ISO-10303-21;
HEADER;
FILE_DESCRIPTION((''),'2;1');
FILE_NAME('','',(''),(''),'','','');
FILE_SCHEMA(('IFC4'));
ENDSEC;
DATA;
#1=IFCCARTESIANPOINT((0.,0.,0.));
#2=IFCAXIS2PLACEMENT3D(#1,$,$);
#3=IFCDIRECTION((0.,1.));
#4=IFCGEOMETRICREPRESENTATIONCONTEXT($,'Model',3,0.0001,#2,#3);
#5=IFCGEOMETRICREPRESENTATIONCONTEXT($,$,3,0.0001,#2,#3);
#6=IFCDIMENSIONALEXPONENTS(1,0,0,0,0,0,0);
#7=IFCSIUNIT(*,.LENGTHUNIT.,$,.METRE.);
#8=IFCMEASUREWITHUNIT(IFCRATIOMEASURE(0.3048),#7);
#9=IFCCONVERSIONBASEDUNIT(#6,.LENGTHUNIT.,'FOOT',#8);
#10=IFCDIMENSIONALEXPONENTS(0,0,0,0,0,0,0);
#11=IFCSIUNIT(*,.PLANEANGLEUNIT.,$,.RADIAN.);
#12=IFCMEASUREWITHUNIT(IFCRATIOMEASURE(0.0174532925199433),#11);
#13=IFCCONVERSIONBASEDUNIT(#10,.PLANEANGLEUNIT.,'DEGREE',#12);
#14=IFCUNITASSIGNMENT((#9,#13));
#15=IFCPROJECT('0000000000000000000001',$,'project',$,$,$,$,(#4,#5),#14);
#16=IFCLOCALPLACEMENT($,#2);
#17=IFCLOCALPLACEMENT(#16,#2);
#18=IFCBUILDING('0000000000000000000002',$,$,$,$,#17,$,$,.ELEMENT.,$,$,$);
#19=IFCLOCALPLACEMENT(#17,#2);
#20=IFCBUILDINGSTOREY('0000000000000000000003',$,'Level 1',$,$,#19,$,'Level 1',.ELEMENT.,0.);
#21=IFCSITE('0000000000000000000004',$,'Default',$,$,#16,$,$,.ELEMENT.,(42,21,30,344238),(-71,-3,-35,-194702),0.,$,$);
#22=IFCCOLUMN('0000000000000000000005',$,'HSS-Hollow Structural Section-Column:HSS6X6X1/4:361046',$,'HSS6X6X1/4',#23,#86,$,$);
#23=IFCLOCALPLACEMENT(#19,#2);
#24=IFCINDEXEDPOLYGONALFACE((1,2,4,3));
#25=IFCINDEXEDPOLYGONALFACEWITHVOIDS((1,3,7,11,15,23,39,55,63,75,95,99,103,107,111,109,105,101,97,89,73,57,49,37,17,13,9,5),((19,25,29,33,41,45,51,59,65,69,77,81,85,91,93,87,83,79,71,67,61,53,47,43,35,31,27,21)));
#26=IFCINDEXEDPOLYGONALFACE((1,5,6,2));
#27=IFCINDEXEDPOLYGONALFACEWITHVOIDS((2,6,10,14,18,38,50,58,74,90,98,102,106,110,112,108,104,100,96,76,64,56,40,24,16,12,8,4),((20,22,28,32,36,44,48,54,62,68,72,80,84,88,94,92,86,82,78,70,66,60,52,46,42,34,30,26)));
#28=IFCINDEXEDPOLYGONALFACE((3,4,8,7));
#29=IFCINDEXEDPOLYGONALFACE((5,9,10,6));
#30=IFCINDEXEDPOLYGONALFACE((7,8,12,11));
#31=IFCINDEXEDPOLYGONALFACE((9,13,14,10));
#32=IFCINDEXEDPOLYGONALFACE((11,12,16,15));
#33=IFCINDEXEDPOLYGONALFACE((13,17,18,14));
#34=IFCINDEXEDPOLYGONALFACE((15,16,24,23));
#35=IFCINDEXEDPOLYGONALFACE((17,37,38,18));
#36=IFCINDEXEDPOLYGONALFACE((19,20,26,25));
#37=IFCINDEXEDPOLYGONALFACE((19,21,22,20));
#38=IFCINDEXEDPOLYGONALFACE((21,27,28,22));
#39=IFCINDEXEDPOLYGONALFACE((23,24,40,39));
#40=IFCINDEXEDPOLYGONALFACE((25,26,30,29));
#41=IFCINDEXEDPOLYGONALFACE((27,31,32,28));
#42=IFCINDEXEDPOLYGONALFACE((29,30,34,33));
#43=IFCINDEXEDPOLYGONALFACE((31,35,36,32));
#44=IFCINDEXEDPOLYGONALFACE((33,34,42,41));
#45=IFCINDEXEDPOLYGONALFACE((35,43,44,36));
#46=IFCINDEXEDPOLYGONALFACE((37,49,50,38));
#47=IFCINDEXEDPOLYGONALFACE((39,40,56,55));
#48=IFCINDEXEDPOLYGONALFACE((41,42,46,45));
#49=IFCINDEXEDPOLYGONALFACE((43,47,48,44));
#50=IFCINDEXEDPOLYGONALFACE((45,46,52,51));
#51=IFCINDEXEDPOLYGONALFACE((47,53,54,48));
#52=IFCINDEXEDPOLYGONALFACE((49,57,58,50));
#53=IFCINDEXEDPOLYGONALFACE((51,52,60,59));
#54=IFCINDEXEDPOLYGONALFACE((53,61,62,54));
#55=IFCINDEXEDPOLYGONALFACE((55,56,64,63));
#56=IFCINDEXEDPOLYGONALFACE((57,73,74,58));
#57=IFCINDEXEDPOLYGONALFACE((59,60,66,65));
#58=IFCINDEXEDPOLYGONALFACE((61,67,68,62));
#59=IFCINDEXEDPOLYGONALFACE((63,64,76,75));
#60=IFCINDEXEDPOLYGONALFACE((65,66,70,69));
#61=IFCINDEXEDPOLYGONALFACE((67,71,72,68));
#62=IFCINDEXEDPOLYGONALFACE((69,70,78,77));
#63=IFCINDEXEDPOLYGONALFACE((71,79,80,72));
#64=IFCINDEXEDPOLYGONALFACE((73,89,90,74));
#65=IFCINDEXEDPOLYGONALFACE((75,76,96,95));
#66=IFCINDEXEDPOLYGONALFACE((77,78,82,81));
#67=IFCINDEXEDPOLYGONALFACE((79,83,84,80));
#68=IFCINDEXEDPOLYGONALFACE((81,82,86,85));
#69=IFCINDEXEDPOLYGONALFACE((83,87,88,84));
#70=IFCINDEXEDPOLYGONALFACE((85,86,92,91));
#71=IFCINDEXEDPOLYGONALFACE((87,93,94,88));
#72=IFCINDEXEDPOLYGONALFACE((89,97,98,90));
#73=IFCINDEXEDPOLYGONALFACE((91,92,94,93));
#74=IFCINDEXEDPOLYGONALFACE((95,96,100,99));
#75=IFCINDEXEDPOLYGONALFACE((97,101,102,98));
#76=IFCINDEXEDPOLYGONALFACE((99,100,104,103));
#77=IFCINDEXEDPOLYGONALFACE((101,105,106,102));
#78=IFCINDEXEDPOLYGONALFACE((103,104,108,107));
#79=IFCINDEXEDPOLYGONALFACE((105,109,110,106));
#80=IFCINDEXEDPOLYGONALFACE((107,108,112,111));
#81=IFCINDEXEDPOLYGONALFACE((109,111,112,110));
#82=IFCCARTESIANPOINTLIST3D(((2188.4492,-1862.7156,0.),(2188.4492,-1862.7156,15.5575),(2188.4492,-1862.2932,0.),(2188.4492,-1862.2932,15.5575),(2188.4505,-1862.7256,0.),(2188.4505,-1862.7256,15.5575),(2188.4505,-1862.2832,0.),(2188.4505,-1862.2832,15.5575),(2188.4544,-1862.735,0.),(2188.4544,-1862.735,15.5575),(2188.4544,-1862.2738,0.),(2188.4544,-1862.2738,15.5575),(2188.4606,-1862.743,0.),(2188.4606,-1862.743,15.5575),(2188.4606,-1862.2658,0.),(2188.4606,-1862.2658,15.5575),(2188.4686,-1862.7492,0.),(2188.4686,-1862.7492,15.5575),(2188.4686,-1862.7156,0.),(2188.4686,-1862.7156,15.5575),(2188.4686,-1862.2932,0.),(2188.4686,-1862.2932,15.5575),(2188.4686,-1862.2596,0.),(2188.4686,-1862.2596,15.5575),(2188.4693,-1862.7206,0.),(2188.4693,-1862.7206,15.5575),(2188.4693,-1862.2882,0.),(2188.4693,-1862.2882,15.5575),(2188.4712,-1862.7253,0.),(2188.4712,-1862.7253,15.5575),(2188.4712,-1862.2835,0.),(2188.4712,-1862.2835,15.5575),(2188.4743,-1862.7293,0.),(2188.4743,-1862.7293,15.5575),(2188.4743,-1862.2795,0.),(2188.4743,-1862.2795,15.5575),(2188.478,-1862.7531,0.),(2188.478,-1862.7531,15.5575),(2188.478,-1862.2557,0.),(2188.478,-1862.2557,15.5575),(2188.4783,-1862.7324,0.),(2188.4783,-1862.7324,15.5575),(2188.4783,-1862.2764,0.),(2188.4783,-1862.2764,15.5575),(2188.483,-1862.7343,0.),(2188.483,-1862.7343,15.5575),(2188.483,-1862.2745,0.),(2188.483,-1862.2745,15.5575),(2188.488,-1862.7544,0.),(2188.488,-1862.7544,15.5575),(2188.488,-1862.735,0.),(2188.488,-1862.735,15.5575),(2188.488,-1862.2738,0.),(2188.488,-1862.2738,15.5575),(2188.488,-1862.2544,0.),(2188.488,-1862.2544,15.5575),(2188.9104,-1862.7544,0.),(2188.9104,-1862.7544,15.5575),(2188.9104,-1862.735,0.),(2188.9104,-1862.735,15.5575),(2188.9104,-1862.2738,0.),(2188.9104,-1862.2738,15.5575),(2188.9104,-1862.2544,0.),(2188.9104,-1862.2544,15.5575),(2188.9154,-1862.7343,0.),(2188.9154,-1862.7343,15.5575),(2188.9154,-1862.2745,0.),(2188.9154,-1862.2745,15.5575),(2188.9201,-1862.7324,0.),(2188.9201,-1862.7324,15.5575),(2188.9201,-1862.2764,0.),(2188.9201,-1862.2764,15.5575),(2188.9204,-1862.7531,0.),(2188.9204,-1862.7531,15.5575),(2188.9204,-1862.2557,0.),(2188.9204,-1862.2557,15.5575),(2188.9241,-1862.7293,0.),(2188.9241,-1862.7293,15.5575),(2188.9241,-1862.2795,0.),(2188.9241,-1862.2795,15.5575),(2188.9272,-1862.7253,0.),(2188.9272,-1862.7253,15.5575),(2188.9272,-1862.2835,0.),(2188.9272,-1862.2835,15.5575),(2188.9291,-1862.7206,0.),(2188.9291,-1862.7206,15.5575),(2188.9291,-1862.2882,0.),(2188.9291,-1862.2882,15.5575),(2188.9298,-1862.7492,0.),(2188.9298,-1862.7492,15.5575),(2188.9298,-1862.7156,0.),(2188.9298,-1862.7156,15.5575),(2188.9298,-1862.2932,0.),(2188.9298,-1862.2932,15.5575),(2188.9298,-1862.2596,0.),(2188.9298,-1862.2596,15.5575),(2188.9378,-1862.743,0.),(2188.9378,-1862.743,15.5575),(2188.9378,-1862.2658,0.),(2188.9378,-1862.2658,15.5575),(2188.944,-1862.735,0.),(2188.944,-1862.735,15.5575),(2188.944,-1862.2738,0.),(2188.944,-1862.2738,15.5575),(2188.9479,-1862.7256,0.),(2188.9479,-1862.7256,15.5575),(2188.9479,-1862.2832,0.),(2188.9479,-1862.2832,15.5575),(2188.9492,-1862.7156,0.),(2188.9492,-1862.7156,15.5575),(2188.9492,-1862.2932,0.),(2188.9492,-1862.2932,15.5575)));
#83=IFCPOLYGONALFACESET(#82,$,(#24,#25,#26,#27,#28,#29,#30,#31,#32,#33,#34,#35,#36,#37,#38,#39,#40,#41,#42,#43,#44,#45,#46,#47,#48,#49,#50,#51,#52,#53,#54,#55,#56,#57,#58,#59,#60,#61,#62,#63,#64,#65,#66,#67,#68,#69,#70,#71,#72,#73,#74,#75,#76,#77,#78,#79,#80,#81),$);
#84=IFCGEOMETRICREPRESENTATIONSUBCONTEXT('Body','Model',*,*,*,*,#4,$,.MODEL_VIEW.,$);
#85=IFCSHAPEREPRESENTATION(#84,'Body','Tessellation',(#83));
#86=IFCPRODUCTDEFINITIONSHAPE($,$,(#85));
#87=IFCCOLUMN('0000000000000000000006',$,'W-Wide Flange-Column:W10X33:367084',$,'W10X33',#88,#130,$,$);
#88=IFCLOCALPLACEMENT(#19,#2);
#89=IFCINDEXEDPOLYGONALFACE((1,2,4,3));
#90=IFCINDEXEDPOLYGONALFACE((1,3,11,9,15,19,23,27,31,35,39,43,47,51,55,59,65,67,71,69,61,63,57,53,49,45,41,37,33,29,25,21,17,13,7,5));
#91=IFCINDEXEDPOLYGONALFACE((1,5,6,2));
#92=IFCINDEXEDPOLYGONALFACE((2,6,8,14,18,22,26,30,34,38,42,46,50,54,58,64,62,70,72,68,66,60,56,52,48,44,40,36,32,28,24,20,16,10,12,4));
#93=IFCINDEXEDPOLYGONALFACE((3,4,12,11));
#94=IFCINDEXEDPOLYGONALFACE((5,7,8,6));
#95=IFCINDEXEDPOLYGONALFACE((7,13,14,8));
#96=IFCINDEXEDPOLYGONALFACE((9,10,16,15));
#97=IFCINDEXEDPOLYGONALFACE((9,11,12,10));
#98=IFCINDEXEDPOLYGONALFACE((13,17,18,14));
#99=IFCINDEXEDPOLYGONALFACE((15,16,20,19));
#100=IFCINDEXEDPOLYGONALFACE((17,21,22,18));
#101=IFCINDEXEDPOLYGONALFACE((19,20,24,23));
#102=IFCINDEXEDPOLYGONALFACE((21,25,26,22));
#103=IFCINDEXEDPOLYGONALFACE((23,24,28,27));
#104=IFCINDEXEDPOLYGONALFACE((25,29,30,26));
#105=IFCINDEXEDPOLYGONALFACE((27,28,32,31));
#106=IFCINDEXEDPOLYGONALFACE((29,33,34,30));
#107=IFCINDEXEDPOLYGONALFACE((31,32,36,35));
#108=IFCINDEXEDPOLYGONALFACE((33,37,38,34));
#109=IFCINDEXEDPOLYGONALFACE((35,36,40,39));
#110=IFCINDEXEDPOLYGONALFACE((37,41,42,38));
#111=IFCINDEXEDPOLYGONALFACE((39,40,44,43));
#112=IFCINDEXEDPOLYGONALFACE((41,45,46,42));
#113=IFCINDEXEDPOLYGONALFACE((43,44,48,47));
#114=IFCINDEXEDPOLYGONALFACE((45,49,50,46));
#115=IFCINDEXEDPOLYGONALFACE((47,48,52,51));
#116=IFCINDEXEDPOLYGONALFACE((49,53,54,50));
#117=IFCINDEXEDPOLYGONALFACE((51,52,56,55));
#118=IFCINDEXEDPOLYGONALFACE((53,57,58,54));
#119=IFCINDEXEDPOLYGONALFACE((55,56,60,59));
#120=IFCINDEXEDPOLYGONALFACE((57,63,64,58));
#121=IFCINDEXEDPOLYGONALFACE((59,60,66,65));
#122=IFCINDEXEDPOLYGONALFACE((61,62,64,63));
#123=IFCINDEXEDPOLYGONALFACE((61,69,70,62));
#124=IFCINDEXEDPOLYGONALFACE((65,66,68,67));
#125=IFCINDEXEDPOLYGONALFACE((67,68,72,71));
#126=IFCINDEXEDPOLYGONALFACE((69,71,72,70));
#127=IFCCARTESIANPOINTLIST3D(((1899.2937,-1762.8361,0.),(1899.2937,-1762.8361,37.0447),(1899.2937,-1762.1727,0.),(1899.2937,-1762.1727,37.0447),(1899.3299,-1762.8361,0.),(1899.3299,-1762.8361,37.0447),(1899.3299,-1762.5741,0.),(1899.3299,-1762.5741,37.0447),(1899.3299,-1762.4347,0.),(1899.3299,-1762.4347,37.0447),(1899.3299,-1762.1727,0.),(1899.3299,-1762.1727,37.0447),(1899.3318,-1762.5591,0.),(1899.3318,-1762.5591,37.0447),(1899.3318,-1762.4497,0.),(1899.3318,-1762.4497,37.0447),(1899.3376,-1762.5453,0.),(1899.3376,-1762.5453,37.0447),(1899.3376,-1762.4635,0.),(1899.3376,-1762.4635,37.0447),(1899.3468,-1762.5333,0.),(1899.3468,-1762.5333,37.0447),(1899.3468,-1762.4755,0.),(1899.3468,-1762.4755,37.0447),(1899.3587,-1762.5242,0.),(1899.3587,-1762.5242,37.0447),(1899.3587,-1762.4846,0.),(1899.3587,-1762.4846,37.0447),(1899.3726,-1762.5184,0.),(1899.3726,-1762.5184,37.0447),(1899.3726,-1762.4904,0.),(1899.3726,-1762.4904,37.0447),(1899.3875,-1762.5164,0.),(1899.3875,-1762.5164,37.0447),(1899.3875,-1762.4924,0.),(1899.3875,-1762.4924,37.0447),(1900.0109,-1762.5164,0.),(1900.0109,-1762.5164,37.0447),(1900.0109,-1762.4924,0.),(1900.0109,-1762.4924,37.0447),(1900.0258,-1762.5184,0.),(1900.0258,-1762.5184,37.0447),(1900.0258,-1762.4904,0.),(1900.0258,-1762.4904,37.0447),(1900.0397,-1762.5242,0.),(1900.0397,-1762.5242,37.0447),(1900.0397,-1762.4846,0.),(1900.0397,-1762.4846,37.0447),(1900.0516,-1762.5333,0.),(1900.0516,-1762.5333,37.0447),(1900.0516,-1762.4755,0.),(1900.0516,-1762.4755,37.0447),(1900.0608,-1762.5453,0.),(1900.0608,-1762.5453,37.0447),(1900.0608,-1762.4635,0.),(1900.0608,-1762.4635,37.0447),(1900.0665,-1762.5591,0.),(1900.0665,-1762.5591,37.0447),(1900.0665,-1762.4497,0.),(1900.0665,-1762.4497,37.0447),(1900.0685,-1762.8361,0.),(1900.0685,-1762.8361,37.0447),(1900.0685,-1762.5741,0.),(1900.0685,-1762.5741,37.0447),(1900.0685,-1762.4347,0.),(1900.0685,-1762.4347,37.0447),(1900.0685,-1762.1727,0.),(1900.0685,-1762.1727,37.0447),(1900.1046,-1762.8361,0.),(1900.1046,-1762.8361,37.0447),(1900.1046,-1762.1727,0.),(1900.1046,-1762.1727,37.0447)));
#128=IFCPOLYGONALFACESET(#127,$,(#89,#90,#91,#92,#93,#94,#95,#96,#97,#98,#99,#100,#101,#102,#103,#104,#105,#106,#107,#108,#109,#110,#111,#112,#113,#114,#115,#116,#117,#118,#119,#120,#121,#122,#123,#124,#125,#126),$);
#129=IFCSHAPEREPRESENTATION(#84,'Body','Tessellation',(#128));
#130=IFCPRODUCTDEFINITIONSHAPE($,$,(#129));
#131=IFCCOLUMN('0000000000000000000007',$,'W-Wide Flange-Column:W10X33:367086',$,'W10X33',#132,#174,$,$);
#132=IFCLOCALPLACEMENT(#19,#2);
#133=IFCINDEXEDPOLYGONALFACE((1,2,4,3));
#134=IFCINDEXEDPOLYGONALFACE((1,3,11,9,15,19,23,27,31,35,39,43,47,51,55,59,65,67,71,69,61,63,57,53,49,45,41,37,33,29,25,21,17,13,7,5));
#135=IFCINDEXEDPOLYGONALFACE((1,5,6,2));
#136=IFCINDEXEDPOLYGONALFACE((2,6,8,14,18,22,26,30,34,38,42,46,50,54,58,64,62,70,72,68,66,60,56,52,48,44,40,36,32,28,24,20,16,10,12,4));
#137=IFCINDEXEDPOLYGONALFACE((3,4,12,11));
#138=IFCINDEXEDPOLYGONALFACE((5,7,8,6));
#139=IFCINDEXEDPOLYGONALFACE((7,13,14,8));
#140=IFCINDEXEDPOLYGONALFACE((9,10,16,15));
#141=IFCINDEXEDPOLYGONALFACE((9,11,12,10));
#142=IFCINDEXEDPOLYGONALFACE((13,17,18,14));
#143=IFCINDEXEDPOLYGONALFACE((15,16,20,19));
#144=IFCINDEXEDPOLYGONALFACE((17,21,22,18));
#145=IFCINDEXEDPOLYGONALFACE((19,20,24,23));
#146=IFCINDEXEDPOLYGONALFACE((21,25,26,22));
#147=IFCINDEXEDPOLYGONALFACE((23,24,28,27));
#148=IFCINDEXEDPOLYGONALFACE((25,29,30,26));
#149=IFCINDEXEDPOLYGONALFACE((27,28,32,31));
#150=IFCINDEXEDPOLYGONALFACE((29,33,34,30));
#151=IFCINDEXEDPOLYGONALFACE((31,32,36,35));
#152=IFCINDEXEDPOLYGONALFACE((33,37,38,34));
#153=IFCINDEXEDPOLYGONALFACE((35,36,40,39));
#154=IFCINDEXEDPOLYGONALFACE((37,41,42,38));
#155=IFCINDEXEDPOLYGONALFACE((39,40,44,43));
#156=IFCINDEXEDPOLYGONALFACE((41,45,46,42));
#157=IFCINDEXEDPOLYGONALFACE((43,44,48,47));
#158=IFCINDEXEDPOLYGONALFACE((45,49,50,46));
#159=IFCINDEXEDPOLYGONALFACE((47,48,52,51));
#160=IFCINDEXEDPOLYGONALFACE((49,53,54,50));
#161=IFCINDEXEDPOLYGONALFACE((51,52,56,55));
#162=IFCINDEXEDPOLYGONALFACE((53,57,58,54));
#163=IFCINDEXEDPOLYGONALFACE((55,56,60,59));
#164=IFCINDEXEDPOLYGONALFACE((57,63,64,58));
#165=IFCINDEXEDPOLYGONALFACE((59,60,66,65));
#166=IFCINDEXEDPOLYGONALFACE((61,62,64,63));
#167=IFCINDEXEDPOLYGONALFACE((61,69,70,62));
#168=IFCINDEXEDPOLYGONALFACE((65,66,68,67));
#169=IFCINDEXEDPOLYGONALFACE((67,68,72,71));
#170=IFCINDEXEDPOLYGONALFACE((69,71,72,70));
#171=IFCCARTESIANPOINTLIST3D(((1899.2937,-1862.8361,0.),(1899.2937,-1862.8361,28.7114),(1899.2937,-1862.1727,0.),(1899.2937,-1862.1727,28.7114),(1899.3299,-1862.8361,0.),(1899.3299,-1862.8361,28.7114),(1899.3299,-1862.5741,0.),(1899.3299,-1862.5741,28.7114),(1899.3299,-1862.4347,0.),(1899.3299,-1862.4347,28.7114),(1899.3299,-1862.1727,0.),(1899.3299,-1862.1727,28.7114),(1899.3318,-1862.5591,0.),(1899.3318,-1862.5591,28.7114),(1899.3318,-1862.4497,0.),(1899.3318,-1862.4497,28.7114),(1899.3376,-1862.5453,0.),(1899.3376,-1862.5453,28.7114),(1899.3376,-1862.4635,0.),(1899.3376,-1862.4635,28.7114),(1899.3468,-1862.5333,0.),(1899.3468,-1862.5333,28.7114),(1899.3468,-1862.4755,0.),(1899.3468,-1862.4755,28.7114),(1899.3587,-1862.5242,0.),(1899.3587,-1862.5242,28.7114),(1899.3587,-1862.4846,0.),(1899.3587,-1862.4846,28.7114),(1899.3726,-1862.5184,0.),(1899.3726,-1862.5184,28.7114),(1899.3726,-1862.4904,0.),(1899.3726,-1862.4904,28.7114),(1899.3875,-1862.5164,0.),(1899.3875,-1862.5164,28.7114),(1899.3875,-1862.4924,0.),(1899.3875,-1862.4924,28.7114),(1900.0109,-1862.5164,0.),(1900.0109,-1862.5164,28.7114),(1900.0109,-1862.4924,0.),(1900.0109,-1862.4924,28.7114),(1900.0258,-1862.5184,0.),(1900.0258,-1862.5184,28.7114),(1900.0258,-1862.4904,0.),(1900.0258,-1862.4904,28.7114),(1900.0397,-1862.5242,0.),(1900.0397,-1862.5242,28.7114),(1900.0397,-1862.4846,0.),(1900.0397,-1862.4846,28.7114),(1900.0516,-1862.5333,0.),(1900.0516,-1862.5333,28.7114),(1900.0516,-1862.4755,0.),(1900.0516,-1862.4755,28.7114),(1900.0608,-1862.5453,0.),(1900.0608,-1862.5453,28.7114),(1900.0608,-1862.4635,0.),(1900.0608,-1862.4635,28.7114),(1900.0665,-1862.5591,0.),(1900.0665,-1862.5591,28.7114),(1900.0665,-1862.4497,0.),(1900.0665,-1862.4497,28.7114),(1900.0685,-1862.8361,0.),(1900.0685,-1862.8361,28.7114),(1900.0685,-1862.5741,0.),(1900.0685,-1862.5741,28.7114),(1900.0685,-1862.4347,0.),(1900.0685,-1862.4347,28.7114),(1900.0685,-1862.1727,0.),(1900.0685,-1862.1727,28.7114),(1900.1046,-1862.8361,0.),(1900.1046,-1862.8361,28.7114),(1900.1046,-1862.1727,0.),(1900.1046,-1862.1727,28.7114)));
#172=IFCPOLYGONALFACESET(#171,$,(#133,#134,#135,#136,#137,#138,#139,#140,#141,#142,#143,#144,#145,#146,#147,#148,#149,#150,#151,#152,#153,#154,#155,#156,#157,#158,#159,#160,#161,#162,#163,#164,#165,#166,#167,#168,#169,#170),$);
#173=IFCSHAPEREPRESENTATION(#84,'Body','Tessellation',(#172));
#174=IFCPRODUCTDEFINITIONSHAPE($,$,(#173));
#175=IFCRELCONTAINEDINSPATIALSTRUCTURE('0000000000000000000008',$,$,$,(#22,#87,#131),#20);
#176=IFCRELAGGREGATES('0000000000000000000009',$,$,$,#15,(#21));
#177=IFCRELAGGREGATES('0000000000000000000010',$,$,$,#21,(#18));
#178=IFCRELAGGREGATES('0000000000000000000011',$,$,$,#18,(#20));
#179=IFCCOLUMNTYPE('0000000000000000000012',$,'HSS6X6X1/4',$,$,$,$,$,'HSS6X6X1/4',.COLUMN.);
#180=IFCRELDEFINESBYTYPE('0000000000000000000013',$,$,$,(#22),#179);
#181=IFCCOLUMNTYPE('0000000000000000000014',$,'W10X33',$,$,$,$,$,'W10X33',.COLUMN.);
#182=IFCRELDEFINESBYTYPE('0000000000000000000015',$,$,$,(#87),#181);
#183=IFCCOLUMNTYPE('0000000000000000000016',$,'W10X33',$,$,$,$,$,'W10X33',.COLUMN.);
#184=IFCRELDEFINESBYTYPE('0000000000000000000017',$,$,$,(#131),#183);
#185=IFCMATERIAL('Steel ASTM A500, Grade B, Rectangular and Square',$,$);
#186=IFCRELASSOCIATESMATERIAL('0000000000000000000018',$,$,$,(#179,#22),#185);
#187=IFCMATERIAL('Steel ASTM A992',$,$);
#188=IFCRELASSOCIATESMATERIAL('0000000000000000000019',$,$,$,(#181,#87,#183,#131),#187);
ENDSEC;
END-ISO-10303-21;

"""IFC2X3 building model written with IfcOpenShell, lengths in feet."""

from ifc_helpers import new_model, entity, si_unit, converted_unit, direction, frame, frame_2d, origin, place, context, subcontext, project, spatial, polyline, circle_curve, parameter, trimmed, segment, composite_curve, i_section, outline, extrude, source, transform, mapped, material, type_object, type_shapes, element, save


model = new_model("IFC2X3")

# Units and contexts
model_context = context("Model", 3, precision=0.0001, world=origin(), true_north=direction((0.0, 1.0)))
context_of_model = context(None, 3, precision=0.0001, world=origin(), true_north=direction((0.0, 1.0)))
body_context = subcontext(model_context, "Body", "Model", "MODEL_VIEW")
ifc_project = project(units=[converted_unit("LENGTHUNIT", "FOOT", entity("IfcRatioMeasure", 0.3048), si_unit("LENGTHUNIT", "METRE"), dimensions=[1, 0, 0, 0, 0, 0, 0]), converted_unit("PLANEANGLEUNIT", "DEGREE", entity("IfcRatioMeasure", 0.0174532925199433), si_unit("PLANEANGLEUNIT", "RADIAN"), dimensions=[0, 0, 0, 0, 0, 0, 0])], contexts=[model_context, context_of_model])

# Site, building, storey
site_placement = place(None, origin())
site = spatial("IfcSite", under=ifc_project, at=site_placement, Name="Default", CompositionType="ELEMENT", RefLatitude=(42, 21, 30, 344238), RefLongitude=(-71, -3, -35, -194702), RefElevation=0.0)
building_placement = place(site_placement, origin())
building = spatial("IfcBuilding", under=site, at=building_placement, CompositionType="ELEMENT")
storey_placement = place(building_placement, origin())
storey = spatial("IfcBuildingStorey", under=building, at=storey_placement, Name="Level 1", LongName="Level 1", CompositionType="ELEMENT", Elevation=0.0)

# Columns
ifc_material_1 = material(Name="Steel ASTM A500, Grade B, Rectangular and Square")
column_type_1 = type_object("IfcColumnType", Name="HSS6X6X1/4", ElementType="HSS6X6X1/4", PredefinedType="COLUMN", material=ifc_material_1)
shared_shape_1 = source(origin(), body_context, "Body", "SweptSolid", [
    extrude(outline(composite_curve([segment(polyline([(-0.2112, -0.25), (0.2112, -0.25)]), True, "CONTINUOUS"), segment(trimmed(circle_curve(frame_2d((0.2112, -0.2112), x_axis=(-1.0, 0.0)), 0.0388), [parameter(90.0)], [parameter(180.0)], True, "PARAMETER"), True, "CONTINUOUS"), segment(polyline([(0.25, -0.2112), (0.25, 0.2112)]), True, "CONTINUOUS"), segment(trimmed(circle_curve(frame_2d((0.2112, 0.2112), x_axis=(-1.0, 0.0)), 0.0388), [parameter(180.0)], [parameter(270.0)], True, "PARAMETER"), True, "CONTINUOUS"), segment(polyline([(0.2112, 0.25), (-0.2112, 0.25)]), True, "CONTINUOUS"), segment(trimmed(circle_curve(frame_2d((-0.2112, 0.2112), x_axis=(-1.0, 0.0)), 0.0388), [parameter(270.0)], [parameter(360.0)], True, "PARAMETER"), True, "CONTINUOUS"), segment(polyline([(-0.25, 0.2112), (-0.25, -0.2112)]), True, "CONTINUOUS"), segment(trimmed(circle_curve(frame_2d((-0.2112, -0.2112), x_axis=(-1.0, 0.0)), 0.0388), [parameter(360.0)], [parameter(90.0)], True, "PARAMETER"), True, "CONTINUOUS")], self_intersect=False), holes=[composite_curve([segment(trimmed(circle_curve(frame_2d((-0.2112, -0.2112), x_axis=(-1.0, 0.0)), 0.0194), [parameter(0.0)], [parameter(90.0)], True, "PARAMETER"), False, "CONTINUOUS"), segment(polyline([(-0.2306, -0.2112), (-0.2306, 0.2112)]), True, "CONTINUOUS"), segment(trimmed(circle_curve(frame_2d((-0.2112, 0.2112), x_axis=(-1.0, 0.0)), 0.0194), [parameter(270.0)], [parameter(360.0)], True, "PARAMETER"), False, "CONTINUOUS"), segment(polyline([(-0.2112, 0.2306), (0.2112, 0.2306)]), True, "CONTINUOUS"), segment(trimmed(circle_curve(frame_2d((0.2112, 0.2112), x_axis=(-1.0, 0.0)), 0.0194), [parameter(180.0)], [parameter(270.0)], True, "PARAMETER"), False, "CONTINUOUS"), segment(polyline([(0.2306, 0.2112), (0.2306, -0.2112)]), True, "CONTINUOUS"), segment(trimmed(circle_curve(frame_2d((0.2112, -0.2112), x_axis=(-1.0, 0.0)), 0.0194), [parameter(90.0)], [parameter(180.0)], True, "PARAMETER"), False, "CONTINUOUS"), segment(polyline([(0.2112, -0.2306), (-0.2112, -0.2306)]), True, "CONTINUOUS")], self_intersect=False)]), frame((2188.6992, -1862.5044, 0.0), z_axis=(0.0, 0.0, 1.0), x_axis=(-1.0, 0.0, 0.0)), (0.0, 0.0, 1.0), 15.5575),
])
type_shapes(column_type_1, [shared_shape_1])
column_1_placement = place(storey_placement, origin())
element("IfcColumn", 1, at=column_1_placement, inside=storey, type_object=column_type_1, material=ifc_material_1, Name="HSS-Hollow Structural Section-Column:HSS6X6X1/4:361046", ObjectType="HSS6X6X1/4", context=body_context, shape_type="MappedRepresentation", body=[
    mapped(shared_shape_1, transform((0.0, 0.0, 0.0), scale=1.0)),
])
ifc_material_2 = material(Name="Steel ASTM A992")
column_type_2 = type_object("IfcColumnType", Name="W10X33", ElementType="W10X33", PredefinedType="COLUMN", material=ifc_material_2)
shared_shape_2 = source(origin(), body_context, "Body", "SweptSolid", [
    extrude(i_section(OverallWidth=0.6634, OverallDepth=0.8109, WebThickness=0.0241, FlangeThickness=0.0361, FilletRadius=0.0576, at=frame_2d((0.0, 0.0), x_axis=(1.0, 0.0))), frame((1899.6992, -1762.5044, 0.0), z_axis=(0.0, 0.0, 1.0), x_axis=(0.0, -1.0, 0.0)), (0.0, 0.0, 1.0), 37.0447),
])
type_shapes(column_type_2, [shared_shape_2])
column_2_placement = place(storey_placement, origin())
element("IfcColumn", 2, at=column_2_placement, inside=storey, type_object=column_type_2, material=ifc_material_2, Name="W-Wide Flange-Column:W10X33:367084", ObjectType="W10X33", context=body_context, shape_type="MappedRepresentation", body=[
    mapped(shared_shape_2, transform((0.0, 0.0, 0.0), scale=1.0)),
])
column_type_3 = type_object("IfcColumnType", Name="W10X33", ElementType="W10X33", PredefinedType="COLUMN", material=ifc_material_2)
shared_shape_3 = source(origin(), body_context, "Body", "SweptSolid", [
    extrude(i_section(OverallWidth=0.6634, OverallDepth=0.8109, WebThickness=0.0241, FlangeThickness=0.0361, FilletRadius=0.0576, at=frame_2d((0.0, 0.0), x_axis=(1.0, 0.0))), frame((1899.6992, -1862.5044, 0.0), z_axis=(0.0, 0.0, 1.0), x_axis=(0.0, -1.0, 0.0)), (0.0, 0.0, 1.0), 28.7114),
])
type_shapes(column_type_3, [shared_shape_3])
column_3_placement = place(storey_placement, origin())
element("IfcColumn", 3, at=column_3_placement, inside=storey, type_object=column_type_3, material=ifc_material_2, Name="W-Wide Flange-Column:W10X33:367086", ObjectType="W10X33", context=body_context, shape_type="MappedRepresentation", body=[
    mapped(shared_shape_3, transform((0.0, 0.0, 0.0), scale=1.0)),
])

save(model, "model.ifc")
